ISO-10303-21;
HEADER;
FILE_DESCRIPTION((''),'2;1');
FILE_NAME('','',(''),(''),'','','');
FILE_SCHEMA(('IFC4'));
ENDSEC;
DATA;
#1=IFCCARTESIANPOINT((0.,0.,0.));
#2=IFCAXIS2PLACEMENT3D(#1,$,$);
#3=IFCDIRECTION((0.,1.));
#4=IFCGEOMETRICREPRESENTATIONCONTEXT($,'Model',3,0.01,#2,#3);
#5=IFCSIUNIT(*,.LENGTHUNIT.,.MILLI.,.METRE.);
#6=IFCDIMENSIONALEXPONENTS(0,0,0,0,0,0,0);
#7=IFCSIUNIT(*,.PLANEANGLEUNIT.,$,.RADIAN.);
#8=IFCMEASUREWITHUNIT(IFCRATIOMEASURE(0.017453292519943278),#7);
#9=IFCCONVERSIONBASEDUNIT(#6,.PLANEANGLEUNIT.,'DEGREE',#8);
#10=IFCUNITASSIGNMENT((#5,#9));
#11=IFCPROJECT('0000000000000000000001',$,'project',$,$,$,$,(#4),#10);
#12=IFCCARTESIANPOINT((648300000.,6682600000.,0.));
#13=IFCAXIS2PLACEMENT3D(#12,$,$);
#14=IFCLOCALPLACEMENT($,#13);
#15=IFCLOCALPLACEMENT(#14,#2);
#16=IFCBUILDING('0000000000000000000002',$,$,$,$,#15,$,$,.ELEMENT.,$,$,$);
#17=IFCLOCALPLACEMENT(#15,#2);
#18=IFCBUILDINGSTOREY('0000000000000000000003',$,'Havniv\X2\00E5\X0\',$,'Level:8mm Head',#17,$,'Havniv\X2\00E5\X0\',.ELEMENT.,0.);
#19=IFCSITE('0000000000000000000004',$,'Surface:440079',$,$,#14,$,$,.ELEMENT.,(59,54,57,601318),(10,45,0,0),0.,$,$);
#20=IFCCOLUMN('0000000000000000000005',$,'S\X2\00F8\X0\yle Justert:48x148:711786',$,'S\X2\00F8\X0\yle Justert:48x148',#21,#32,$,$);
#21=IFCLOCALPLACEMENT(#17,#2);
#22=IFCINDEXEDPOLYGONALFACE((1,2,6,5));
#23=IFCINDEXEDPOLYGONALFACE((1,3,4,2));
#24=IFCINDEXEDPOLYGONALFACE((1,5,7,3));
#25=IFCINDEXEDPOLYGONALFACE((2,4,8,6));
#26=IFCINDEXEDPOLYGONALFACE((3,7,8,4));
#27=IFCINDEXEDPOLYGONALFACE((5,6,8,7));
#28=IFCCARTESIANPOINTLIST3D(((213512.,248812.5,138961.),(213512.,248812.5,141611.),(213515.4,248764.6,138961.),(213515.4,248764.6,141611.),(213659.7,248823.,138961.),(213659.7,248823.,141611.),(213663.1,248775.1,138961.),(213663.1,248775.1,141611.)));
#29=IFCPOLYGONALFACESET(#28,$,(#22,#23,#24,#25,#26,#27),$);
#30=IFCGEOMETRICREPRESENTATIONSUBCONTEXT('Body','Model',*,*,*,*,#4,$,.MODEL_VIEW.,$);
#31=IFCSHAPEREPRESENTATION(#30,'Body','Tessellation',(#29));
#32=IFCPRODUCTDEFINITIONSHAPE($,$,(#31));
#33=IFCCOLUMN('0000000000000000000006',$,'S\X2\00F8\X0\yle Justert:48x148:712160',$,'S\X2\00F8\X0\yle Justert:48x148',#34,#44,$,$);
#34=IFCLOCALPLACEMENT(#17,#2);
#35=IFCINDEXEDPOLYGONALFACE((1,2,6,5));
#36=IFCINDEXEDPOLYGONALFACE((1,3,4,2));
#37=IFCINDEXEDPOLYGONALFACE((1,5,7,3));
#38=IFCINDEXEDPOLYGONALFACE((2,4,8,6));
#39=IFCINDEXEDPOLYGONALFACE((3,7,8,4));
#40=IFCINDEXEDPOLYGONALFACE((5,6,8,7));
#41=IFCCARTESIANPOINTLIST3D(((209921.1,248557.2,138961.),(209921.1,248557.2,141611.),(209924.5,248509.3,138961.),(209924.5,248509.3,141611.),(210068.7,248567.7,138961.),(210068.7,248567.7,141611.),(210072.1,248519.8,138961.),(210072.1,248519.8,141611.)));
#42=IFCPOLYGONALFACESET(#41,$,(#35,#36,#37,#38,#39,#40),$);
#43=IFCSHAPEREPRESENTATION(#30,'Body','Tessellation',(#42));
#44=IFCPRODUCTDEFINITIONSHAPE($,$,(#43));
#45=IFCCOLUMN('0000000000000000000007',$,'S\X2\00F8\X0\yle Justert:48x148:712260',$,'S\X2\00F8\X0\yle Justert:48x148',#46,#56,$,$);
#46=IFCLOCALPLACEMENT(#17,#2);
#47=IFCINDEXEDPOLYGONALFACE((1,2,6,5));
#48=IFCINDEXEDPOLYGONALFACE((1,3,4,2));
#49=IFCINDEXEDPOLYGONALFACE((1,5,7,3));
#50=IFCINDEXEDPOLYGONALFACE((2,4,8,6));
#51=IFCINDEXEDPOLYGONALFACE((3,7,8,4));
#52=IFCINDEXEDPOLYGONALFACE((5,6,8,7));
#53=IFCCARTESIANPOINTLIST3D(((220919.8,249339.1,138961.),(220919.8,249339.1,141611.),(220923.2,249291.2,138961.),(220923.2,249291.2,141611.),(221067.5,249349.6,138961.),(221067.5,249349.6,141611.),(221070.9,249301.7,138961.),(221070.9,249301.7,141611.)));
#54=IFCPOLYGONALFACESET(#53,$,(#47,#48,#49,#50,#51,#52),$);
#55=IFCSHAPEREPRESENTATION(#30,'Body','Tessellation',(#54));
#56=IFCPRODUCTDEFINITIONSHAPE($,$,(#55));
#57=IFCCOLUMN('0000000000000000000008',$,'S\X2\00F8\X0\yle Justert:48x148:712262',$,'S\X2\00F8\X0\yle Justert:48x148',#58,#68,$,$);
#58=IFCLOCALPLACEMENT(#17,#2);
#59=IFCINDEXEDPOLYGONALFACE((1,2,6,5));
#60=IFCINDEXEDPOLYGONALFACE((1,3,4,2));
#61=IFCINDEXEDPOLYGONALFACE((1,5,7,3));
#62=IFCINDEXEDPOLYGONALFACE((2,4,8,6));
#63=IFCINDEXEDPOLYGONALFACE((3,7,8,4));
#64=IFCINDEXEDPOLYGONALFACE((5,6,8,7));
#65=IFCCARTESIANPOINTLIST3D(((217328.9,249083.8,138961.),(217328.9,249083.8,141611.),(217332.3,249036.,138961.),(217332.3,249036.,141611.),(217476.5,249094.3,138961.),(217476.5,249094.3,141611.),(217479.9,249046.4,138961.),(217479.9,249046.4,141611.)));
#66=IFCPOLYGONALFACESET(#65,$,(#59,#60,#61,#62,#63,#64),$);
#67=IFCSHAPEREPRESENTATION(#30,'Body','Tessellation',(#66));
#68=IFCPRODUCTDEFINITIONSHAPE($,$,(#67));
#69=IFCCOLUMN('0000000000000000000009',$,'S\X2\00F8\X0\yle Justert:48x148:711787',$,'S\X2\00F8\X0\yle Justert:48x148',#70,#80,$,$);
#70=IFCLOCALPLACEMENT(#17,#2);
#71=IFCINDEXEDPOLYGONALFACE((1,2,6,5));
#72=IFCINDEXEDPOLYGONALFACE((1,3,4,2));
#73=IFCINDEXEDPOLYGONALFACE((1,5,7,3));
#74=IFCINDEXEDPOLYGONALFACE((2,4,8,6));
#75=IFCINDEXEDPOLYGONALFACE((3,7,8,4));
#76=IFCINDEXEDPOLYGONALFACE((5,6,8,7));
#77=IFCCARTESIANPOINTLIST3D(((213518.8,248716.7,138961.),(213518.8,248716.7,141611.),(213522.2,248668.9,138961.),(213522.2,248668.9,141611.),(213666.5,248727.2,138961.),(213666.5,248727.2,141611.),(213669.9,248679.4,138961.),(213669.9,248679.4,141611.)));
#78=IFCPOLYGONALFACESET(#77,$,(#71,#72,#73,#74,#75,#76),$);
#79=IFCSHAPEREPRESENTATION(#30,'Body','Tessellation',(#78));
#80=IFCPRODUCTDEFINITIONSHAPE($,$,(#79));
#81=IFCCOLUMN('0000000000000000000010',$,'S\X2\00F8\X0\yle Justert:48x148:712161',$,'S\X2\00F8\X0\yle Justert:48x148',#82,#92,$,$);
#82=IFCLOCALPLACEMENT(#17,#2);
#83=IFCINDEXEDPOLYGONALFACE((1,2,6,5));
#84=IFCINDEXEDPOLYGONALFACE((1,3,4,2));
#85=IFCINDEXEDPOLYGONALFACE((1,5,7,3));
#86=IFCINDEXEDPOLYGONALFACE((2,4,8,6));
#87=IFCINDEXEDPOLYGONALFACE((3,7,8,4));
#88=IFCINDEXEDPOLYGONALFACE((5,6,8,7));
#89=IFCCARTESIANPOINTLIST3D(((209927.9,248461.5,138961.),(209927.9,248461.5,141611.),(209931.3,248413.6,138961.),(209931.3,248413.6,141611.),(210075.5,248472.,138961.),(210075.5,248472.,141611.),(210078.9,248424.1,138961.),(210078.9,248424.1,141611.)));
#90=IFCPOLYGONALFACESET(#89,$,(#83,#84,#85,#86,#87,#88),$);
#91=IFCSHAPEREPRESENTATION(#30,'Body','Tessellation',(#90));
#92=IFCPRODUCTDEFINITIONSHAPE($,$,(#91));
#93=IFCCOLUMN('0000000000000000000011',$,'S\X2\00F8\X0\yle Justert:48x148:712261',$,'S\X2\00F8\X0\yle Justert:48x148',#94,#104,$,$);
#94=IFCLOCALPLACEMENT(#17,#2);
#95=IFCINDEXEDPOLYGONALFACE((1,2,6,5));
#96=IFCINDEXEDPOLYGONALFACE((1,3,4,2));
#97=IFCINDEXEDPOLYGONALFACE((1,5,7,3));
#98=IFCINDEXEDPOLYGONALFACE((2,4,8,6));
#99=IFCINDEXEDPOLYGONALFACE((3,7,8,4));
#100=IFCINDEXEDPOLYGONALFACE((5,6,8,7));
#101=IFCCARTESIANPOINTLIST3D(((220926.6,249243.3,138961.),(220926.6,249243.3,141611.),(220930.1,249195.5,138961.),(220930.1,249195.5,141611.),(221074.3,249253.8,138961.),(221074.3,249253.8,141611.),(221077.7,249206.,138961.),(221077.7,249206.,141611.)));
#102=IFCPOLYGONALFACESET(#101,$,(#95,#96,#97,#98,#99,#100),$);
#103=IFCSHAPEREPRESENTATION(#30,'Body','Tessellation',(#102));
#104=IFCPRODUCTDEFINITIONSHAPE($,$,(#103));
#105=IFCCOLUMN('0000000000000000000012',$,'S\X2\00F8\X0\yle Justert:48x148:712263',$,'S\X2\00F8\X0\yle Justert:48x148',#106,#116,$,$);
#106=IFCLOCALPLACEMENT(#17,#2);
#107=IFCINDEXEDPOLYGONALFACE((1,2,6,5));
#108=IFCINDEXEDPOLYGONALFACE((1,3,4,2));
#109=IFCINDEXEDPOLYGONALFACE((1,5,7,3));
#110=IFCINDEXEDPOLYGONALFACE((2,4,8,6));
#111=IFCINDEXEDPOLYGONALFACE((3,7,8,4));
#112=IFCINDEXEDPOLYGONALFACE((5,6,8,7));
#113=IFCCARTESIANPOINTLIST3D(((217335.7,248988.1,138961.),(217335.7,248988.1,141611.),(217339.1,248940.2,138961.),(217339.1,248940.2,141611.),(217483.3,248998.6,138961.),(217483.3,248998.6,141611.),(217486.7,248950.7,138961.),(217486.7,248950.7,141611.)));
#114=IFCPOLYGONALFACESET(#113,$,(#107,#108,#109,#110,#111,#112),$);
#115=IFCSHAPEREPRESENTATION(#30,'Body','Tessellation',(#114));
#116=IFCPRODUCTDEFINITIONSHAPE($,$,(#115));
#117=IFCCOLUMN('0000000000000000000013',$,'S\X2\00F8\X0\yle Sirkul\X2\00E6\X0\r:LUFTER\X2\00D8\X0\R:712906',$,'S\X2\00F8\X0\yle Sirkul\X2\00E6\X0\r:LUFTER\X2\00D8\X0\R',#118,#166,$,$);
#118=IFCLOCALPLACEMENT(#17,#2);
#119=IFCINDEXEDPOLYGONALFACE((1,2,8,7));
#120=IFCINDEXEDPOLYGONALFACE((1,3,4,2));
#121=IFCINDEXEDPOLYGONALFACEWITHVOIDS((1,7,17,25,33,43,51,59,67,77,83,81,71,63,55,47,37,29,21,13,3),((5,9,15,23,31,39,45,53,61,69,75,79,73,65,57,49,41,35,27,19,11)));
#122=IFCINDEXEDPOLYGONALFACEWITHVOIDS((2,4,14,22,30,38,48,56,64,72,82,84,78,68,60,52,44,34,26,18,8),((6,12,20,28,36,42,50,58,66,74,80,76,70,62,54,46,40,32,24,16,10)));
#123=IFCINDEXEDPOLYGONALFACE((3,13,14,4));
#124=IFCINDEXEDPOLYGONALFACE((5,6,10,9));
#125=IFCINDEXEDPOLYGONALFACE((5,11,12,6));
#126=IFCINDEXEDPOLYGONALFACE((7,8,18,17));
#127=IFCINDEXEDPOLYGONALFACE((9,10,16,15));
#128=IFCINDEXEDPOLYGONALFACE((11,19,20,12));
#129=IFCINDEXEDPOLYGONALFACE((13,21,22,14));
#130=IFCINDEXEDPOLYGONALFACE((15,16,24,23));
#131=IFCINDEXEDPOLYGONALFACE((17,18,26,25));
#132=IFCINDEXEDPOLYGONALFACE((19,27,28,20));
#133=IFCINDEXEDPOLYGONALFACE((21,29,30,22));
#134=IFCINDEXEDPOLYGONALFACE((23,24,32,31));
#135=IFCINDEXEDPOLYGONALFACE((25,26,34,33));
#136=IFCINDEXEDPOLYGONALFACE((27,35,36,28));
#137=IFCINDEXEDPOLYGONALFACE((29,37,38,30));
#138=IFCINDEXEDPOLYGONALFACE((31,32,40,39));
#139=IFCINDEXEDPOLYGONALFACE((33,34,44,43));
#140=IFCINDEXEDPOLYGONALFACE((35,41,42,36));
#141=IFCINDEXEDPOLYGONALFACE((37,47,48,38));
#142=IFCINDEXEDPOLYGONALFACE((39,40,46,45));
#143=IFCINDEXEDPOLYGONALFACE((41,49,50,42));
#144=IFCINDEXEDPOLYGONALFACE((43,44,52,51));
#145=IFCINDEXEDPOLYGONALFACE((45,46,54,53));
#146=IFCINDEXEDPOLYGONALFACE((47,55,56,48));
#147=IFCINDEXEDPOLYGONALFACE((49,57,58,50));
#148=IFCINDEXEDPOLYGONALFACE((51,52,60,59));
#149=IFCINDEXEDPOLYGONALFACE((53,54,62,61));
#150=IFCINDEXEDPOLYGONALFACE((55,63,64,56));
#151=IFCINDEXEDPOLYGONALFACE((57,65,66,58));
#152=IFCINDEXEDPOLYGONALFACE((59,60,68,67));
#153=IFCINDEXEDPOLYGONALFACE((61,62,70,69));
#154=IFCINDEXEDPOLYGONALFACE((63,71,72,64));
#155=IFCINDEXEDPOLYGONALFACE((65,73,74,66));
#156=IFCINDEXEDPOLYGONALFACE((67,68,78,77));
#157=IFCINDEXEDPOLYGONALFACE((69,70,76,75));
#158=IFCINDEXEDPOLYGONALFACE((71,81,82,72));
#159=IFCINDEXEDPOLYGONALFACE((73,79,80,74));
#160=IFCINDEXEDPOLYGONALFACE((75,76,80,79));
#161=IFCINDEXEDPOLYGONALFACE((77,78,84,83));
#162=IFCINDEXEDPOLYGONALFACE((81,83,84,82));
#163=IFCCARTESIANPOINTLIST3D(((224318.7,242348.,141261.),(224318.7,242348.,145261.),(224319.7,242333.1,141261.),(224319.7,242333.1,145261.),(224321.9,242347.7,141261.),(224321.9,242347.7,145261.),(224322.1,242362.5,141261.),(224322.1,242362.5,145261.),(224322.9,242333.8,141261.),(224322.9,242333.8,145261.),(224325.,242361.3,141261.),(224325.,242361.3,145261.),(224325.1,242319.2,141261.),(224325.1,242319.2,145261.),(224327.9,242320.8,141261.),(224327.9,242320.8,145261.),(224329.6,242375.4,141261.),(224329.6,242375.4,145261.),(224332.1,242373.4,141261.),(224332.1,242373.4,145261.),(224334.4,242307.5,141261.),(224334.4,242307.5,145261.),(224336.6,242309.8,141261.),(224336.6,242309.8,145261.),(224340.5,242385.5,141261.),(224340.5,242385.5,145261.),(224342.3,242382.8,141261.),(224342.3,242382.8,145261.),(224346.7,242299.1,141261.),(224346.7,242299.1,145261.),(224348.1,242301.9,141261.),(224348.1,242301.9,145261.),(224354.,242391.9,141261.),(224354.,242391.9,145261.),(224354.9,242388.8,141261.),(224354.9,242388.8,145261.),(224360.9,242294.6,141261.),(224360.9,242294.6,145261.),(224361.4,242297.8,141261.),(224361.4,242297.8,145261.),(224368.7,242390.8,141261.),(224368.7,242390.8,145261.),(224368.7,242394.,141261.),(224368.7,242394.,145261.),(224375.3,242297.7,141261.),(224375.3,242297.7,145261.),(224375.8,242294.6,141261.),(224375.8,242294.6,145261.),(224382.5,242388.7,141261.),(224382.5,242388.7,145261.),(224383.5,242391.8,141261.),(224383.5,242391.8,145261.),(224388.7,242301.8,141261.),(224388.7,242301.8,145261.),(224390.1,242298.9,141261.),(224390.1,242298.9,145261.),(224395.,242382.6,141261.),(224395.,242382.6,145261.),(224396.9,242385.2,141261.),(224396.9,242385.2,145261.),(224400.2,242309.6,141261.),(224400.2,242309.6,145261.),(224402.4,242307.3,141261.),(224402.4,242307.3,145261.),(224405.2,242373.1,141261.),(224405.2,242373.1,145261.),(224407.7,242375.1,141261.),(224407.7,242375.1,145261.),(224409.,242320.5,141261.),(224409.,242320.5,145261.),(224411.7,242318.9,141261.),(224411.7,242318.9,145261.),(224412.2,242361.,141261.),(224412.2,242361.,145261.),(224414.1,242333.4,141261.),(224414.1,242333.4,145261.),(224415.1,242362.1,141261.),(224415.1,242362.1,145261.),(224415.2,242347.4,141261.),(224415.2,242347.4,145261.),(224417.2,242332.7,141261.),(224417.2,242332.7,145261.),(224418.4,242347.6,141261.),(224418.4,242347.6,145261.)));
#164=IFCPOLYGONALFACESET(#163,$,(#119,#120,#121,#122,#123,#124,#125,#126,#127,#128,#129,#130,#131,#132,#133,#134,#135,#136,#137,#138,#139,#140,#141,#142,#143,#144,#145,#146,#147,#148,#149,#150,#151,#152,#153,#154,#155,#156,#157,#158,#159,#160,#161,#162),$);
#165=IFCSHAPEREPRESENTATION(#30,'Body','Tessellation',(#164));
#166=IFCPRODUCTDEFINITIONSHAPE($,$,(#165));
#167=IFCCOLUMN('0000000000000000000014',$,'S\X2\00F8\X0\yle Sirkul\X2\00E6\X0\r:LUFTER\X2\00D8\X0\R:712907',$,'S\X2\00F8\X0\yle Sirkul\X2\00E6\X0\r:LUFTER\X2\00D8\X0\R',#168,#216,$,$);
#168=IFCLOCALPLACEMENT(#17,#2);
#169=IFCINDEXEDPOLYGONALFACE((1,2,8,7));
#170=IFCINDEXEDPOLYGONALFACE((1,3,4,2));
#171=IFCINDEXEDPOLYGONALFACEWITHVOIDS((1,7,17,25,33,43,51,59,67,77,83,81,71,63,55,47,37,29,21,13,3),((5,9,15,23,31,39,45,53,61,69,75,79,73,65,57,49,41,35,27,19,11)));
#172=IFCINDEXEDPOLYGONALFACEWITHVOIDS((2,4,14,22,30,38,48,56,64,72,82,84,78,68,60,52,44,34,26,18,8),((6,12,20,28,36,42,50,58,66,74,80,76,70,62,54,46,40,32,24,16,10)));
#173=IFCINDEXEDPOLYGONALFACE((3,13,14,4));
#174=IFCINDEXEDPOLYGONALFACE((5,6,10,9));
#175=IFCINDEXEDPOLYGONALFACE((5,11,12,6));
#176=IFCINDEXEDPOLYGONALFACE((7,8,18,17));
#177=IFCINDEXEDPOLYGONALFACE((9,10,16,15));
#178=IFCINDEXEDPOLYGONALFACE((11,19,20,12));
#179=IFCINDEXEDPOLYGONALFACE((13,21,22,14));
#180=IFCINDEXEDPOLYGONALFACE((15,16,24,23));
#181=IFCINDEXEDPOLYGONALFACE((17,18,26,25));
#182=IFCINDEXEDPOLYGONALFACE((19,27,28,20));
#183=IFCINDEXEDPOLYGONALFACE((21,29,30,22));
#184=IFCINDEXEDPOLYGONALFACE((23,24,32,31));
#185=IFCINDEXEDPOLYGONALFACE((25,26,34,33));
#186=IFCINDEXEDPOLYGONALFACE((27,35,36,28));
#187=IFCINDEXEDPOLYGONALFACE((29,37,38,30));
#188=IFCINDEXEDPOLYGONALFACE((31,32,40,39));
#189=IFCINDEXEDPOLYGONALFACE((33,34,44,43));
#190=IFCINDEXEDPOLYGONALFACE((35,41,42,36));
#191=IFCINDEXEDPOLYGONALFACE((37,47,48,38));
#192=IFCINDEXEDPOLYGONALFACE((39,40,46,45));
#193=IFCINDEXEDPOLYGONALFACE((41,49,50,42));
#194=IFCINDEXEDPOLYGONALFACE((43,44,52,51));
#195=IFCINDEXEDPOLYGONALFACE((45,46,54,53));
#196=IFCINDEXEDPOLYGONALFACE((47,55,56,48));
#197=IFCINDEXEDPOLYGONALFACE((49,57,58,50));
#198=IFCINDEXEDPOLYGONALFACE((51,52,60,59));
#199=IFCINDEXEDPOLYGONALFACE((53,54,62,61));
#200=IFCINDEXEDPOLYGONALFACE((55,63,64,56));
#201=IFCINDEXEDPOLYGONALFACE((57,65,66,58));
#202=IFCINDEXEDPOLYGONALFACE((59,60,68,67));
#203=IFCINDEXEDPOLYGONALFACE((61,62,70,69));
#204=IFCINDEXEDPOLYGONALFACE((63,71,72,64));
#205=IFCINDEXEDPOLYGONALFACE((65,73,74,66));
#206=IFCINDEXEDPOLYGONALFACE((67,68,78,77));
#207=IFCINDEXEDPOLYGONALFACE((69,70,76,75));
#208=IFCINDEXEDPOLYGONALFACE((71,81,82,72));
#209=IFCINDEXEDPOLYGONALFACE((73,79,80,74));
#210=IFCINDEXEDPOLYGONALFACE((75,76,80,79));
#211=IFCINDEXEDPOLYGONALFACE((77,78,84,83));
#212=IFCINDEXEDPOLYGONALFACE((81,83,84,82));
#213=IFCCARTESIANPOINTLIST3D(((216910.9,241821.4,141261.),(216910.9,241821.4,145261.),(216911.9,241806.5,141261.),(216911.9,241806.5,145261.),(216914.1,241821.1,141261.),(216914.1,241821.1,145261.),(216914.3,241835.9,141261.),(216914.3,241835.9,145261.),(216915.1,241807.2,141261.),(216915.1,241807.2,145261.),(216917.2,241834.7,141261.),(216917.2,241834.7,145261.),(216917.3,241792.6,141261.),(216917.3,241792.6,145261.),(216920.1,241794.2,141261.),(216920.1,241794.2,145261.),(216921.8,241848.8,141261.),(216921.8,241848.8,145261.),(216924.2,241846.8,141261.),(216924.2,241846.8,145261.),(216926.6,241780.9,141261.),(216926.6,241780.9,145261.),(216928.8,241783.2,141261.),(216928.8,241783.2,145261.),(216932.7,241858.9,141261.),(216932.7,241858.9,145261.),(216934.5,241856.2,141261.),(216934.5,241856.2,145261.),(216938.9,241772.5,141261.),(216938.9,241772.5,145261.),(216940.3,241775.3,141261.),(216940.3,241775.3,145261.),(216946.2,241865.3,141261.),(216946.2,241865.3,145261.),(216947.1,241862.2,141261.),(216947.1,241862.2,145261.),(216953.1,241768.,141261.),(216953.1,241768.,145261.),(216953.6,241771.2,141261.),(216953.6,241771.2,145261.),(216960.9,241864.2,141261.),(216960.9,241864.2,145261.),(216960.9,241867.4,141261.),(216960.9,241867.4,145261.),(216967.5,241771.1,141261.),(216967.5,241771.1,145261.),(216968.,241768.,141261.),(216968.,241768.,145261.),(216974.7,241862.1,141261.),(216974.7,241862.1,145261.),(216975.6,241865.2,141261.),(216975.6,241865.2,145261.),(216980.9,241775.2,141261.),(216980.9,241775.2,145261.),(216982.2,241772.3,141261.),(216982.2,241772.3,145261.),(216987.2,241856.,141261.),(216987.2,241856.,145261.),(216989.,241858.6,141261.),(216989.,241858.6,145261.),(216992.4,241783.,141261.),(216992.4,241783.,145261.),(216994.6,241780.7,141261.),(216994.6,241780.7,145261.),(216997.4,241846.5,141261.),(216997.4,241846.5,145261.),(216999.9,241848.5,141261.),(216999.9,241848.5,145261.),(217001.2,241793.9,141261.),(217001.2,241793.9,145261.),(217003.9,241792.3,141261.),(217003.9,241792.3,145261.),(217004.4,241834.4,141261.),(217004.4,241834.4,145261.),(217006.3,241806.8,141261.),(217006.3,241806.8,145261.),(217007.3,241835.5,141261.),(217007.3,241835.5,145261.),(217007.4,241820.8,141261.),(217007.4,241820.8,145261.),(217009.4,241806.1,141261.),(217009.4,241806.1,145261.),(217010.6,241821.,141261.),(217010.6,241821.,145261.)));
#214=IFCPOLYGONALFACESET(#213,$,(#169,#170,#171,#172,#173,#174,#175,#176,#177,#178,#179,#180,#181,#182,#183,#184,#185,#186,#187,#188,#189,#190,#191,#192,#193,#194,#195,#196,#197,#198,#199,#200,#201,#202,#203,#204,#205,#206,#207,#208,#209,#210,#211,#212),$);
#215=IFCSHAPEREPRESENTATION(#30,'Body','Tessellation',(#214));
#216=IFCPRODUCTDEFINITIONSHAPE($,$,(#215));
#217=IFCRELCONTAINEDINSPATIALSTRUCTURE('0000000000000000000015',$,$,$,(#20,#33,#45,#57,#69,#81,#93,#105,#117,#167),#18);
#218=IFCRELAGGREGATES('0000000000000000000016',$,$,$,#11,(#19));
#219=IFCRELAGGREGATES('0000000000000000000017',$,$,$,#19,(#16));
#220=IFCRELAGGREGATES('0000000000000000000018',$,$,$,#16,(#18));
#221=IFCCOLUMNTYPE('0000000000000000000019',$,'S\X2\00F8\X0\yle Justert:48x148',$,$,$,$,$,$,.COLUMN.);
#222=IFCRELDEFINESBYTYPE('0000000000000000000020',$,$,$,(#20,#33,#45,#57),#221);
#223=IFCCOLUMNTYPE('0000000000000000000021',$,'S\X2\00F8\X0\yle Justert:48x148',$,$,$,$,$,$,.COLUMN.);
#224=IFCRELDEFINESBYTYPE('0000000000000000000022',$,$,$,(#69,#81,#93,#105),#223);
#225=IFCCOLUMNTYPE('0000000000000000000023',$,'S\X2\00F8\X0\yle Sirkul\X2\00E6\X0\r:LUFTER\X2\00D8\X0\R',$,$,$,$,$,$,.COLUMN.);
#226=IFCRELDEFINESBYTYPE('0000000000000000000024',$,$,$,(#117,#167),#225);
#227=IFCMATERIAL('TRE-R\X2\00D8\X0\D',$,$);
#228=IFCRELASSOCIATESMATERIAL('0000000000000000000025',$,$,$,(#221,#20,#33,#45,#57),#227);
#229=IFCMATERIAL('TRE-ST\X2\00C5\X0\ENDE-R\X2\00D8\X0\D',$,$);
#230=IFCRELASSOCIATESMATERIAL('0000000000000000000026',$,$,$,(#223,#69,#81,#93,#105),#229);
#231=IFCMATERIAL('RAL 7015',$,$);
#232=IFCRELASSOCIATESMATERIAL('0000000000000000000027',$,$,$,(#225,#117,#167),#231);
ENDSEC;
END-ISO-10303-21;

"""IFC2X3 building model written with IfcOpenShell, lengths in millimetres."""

from ifc_helpers import new_model, entity, si_unit, converted_unit, direction, frame, frame_2d, origin, origin_2d_with_axis, place, context, subcontext, project, spatial, rectangle, hollow_circle, extrude, source, transform, mapped, material, type_object, type_shapes, element, save


model = new_model("IFC2X3")

# Units and contexts
model_context = context("Model", 3, precision=0.01, world=origin(), true_north=direction((0.0, 1.0)))
body_context = subcontext(model_context, "Body", "Model", "MODEL_VIEW")
ifc_project = project(units=[si_unit("LENGTHUNIT", "METRE", prefix="MILLI"), converted_unit("PLANEANGLEUNIT", "DEGREE", entity("IfcRatioMeasure", 0.017453292519943278), si_unit("PLANEANGLEUNIT", "RADIAN"), dimensions=[0, 0, 0, 0, 0, 0, 0])], contexts=[model_context])

# Site, building, storey
site_placement = place(None, frame((648300000.0, 6682600000.0, 0.0)))
site = spatial("IfcSite", under=ifc_project, at=site_placement, Name="Surface:440079", CompositionType="ELEMENT", RefLatitude=(59, 54, 57, 601318), RefLongitude=(10, 45, 0, 0), RefElevation=0.0)
building_placement = place(site_placement, origin())
building = spatial("IfcBuilding", under=site, at=building_placement, CompositionType="ELEMENT")
storey_placement = place(building_placement, origin())
storey = spatial("IfcBuildingStorey", under=building, at=storey_placement, Name="Havnivå", ObjectType="Level:8mm Head", LongName="Havnivå", CompositionType="ELEMENT", Elevation=0.0)

# Columns
ifc_material_1 = material(Name="TRE-RØD")
column_type_1 = type_object("IfcColumnType", Name="Søyle Justert:48x148", PredefinedType="COLUMN", material=ifc_material_1)
shared_shape_1 = source(origin(), body_context, "Body", "SweptSolid", [
    extrude(rectangle(XDim=48.0, YDim=148.0, at=origin_2d_with_axis()), frame((0.0, 0.0, 138961.0), z_axis=(0.0, 0.0, 1.0), x_axis=(0.0, -1.0, 0.0)), (0.0, 0.0, 1.0), 2650.0),
])
type_shapes(column_type_1, [shared_shape_1])
for number, where, z_axis, x_axis, name in (
    (1, (213587.5, 248793.8, 0.0), (0.0, 0.0, 1.0), (-0.997483, -0.070908, 0.0), "Søyle Justert:48x148:711786"),
    (2, (209996.6, 248538.5, 0.0), (0.0, 0.0, 1.0), (-0.997483, -0.070908, 0.0), "Søyle Justert:48x148:712160"),
    (3, (220995.4, 249320.4, 0.0), (0.0, 0.0, 1.0), (-0.997483, -0.070908, 0.0), "Søyle Justert:48x148:712260"),
    (4, (217404.4, 249065.1, 0.0), (0.0, 0.0, 1.0), (-0.997483, -0.070908, 0.0), "Søyle Justert:48x148:712262"),
):
    element("IfcColumn", number, at=place(storey_placement, frame(where, z_axis=z_axis, x_axis=x_axis)), inside=storey, type_object=column_type_1, material=ifc_material_1, Name=name, ObjectType="Søyle Justert:48x148", context=body_context, shape_type="MappedRepresentation", body=[
        mapped(shared_shape_1, transform((0.0, 0.0, 0.0), scale=1.0)),
    ])
ifc_material_2 = material(Name="TRE-STÅENDE-RØD")
column_type_2 = type_object("IfcColumnType", Name="Søyle Justert:48x148", PredefinedType="COLUMN", material=ifc_material_2)
shared_shape_2 = source(origin(), body_context, "Body", "SweptSolid", [
    extrude(rectangle(XDim=48.0, YDim=148.0, at=origin_2d_with_axis()), frame((0.0, 0.0, 138961.0), z_axis=(0.0, 0.0, 1.0), x_axis=(0.0, -1.0, 0.0)), (0.0, 0.0, 1.0), 2650.0),
])
type_shapes(column_type_2, [shared_shape_2])
for number, where, z_axis, x_axis, name in (
    (5, (213594.4, 248698.0, 0.0), (0.0, 0.0, 1.0), (0.997483, 0.070908, 0.0), "Søyle Justert:48x148:711787"),
    (6, (210003.4, 248442.8, 0.0), (0.0, 0.0, 1.0), (0.997483, 0.070908, 0.0), "Søyle Justert:48x148:712161"),
    (7, (221002.2, 249224.7, 0.0), (0.0, 0.0, 1.0), (0.997483, 0.070908, 0.0), "Søyle Justert:48x148:712261"),
    (8, (217411.2, 248969.4, 0.0), (0.0, 0.0, 1.0), (0.997483, 0.070908, 0.0), "Søyle Justert:48x148:712263"),
):
    element("IfcColumn", number, at=place(storey_placement, frame(where, z_axis=z_axis, x_axis=x_axis)), inside=storey, type_object=column_type_2, material=ifc_material_2, Name=name, ObjectType="Søyle Justert:48x148", context=body_context, shape_type="MappedRepresentation", body=[
        mapped(shared_shape_2, transform((0.0, 0.0, 0.0), scale=1.0)),
    ])
ifc_material_3 = material(Name="RAL 7015")
column_type_3 = type_object("IfcColumnType", Name="Søyle Sirkulær:LUFTERØR", PredefinedType="COLUMN", material=ifc_material_3)
shared_shape_3 = source(origin(), body_context, "Body", "SweptSolid", [
    extrude(hollow_circle(Radius=50.0, WallThickness=3.2, at=frame_2d((0.0, 0.0), x_axis=(1.0, 0.0))), frame((-0.2, -0.2, 141261.0)), (0.0, 0.0, 1.0), 4000.0),
])
type_shapes(column_type_3, [shared_shape_3])
for number, where, z_axis, x_axis, name in (
    (9, (224368.7, 242344.2, 0.0), (0.0, 0.0, 1.0), (0.997483, 0.070908, 0.0), "Søyle Sirkulær:LUFTERØR:712906"),
    (10, (216960.9, 241817.6, 0.0), (0.0, 0.0, 1.0), (0.997483, 0.070908, 0.0), "Søyle Sirkulær:LUFTERØR:712907"),
):
    element("IfcColumn", number, at=place(storey_placement, frame(where, z_axis=z_axis, x_axis=x_axis)), inside=storey, type_object=column_type_3, material=ifc_material_3, Name=name, ObjectType="Søyle Sirkulær:LUFTERØR", context=body_context, shape_type="MappedRepresentation", body=[
        mapped(shared_shape_3, transform((0.0, 0.0, 0.0), scale=1.0)),
    ])

save(model, "model.ifc")
